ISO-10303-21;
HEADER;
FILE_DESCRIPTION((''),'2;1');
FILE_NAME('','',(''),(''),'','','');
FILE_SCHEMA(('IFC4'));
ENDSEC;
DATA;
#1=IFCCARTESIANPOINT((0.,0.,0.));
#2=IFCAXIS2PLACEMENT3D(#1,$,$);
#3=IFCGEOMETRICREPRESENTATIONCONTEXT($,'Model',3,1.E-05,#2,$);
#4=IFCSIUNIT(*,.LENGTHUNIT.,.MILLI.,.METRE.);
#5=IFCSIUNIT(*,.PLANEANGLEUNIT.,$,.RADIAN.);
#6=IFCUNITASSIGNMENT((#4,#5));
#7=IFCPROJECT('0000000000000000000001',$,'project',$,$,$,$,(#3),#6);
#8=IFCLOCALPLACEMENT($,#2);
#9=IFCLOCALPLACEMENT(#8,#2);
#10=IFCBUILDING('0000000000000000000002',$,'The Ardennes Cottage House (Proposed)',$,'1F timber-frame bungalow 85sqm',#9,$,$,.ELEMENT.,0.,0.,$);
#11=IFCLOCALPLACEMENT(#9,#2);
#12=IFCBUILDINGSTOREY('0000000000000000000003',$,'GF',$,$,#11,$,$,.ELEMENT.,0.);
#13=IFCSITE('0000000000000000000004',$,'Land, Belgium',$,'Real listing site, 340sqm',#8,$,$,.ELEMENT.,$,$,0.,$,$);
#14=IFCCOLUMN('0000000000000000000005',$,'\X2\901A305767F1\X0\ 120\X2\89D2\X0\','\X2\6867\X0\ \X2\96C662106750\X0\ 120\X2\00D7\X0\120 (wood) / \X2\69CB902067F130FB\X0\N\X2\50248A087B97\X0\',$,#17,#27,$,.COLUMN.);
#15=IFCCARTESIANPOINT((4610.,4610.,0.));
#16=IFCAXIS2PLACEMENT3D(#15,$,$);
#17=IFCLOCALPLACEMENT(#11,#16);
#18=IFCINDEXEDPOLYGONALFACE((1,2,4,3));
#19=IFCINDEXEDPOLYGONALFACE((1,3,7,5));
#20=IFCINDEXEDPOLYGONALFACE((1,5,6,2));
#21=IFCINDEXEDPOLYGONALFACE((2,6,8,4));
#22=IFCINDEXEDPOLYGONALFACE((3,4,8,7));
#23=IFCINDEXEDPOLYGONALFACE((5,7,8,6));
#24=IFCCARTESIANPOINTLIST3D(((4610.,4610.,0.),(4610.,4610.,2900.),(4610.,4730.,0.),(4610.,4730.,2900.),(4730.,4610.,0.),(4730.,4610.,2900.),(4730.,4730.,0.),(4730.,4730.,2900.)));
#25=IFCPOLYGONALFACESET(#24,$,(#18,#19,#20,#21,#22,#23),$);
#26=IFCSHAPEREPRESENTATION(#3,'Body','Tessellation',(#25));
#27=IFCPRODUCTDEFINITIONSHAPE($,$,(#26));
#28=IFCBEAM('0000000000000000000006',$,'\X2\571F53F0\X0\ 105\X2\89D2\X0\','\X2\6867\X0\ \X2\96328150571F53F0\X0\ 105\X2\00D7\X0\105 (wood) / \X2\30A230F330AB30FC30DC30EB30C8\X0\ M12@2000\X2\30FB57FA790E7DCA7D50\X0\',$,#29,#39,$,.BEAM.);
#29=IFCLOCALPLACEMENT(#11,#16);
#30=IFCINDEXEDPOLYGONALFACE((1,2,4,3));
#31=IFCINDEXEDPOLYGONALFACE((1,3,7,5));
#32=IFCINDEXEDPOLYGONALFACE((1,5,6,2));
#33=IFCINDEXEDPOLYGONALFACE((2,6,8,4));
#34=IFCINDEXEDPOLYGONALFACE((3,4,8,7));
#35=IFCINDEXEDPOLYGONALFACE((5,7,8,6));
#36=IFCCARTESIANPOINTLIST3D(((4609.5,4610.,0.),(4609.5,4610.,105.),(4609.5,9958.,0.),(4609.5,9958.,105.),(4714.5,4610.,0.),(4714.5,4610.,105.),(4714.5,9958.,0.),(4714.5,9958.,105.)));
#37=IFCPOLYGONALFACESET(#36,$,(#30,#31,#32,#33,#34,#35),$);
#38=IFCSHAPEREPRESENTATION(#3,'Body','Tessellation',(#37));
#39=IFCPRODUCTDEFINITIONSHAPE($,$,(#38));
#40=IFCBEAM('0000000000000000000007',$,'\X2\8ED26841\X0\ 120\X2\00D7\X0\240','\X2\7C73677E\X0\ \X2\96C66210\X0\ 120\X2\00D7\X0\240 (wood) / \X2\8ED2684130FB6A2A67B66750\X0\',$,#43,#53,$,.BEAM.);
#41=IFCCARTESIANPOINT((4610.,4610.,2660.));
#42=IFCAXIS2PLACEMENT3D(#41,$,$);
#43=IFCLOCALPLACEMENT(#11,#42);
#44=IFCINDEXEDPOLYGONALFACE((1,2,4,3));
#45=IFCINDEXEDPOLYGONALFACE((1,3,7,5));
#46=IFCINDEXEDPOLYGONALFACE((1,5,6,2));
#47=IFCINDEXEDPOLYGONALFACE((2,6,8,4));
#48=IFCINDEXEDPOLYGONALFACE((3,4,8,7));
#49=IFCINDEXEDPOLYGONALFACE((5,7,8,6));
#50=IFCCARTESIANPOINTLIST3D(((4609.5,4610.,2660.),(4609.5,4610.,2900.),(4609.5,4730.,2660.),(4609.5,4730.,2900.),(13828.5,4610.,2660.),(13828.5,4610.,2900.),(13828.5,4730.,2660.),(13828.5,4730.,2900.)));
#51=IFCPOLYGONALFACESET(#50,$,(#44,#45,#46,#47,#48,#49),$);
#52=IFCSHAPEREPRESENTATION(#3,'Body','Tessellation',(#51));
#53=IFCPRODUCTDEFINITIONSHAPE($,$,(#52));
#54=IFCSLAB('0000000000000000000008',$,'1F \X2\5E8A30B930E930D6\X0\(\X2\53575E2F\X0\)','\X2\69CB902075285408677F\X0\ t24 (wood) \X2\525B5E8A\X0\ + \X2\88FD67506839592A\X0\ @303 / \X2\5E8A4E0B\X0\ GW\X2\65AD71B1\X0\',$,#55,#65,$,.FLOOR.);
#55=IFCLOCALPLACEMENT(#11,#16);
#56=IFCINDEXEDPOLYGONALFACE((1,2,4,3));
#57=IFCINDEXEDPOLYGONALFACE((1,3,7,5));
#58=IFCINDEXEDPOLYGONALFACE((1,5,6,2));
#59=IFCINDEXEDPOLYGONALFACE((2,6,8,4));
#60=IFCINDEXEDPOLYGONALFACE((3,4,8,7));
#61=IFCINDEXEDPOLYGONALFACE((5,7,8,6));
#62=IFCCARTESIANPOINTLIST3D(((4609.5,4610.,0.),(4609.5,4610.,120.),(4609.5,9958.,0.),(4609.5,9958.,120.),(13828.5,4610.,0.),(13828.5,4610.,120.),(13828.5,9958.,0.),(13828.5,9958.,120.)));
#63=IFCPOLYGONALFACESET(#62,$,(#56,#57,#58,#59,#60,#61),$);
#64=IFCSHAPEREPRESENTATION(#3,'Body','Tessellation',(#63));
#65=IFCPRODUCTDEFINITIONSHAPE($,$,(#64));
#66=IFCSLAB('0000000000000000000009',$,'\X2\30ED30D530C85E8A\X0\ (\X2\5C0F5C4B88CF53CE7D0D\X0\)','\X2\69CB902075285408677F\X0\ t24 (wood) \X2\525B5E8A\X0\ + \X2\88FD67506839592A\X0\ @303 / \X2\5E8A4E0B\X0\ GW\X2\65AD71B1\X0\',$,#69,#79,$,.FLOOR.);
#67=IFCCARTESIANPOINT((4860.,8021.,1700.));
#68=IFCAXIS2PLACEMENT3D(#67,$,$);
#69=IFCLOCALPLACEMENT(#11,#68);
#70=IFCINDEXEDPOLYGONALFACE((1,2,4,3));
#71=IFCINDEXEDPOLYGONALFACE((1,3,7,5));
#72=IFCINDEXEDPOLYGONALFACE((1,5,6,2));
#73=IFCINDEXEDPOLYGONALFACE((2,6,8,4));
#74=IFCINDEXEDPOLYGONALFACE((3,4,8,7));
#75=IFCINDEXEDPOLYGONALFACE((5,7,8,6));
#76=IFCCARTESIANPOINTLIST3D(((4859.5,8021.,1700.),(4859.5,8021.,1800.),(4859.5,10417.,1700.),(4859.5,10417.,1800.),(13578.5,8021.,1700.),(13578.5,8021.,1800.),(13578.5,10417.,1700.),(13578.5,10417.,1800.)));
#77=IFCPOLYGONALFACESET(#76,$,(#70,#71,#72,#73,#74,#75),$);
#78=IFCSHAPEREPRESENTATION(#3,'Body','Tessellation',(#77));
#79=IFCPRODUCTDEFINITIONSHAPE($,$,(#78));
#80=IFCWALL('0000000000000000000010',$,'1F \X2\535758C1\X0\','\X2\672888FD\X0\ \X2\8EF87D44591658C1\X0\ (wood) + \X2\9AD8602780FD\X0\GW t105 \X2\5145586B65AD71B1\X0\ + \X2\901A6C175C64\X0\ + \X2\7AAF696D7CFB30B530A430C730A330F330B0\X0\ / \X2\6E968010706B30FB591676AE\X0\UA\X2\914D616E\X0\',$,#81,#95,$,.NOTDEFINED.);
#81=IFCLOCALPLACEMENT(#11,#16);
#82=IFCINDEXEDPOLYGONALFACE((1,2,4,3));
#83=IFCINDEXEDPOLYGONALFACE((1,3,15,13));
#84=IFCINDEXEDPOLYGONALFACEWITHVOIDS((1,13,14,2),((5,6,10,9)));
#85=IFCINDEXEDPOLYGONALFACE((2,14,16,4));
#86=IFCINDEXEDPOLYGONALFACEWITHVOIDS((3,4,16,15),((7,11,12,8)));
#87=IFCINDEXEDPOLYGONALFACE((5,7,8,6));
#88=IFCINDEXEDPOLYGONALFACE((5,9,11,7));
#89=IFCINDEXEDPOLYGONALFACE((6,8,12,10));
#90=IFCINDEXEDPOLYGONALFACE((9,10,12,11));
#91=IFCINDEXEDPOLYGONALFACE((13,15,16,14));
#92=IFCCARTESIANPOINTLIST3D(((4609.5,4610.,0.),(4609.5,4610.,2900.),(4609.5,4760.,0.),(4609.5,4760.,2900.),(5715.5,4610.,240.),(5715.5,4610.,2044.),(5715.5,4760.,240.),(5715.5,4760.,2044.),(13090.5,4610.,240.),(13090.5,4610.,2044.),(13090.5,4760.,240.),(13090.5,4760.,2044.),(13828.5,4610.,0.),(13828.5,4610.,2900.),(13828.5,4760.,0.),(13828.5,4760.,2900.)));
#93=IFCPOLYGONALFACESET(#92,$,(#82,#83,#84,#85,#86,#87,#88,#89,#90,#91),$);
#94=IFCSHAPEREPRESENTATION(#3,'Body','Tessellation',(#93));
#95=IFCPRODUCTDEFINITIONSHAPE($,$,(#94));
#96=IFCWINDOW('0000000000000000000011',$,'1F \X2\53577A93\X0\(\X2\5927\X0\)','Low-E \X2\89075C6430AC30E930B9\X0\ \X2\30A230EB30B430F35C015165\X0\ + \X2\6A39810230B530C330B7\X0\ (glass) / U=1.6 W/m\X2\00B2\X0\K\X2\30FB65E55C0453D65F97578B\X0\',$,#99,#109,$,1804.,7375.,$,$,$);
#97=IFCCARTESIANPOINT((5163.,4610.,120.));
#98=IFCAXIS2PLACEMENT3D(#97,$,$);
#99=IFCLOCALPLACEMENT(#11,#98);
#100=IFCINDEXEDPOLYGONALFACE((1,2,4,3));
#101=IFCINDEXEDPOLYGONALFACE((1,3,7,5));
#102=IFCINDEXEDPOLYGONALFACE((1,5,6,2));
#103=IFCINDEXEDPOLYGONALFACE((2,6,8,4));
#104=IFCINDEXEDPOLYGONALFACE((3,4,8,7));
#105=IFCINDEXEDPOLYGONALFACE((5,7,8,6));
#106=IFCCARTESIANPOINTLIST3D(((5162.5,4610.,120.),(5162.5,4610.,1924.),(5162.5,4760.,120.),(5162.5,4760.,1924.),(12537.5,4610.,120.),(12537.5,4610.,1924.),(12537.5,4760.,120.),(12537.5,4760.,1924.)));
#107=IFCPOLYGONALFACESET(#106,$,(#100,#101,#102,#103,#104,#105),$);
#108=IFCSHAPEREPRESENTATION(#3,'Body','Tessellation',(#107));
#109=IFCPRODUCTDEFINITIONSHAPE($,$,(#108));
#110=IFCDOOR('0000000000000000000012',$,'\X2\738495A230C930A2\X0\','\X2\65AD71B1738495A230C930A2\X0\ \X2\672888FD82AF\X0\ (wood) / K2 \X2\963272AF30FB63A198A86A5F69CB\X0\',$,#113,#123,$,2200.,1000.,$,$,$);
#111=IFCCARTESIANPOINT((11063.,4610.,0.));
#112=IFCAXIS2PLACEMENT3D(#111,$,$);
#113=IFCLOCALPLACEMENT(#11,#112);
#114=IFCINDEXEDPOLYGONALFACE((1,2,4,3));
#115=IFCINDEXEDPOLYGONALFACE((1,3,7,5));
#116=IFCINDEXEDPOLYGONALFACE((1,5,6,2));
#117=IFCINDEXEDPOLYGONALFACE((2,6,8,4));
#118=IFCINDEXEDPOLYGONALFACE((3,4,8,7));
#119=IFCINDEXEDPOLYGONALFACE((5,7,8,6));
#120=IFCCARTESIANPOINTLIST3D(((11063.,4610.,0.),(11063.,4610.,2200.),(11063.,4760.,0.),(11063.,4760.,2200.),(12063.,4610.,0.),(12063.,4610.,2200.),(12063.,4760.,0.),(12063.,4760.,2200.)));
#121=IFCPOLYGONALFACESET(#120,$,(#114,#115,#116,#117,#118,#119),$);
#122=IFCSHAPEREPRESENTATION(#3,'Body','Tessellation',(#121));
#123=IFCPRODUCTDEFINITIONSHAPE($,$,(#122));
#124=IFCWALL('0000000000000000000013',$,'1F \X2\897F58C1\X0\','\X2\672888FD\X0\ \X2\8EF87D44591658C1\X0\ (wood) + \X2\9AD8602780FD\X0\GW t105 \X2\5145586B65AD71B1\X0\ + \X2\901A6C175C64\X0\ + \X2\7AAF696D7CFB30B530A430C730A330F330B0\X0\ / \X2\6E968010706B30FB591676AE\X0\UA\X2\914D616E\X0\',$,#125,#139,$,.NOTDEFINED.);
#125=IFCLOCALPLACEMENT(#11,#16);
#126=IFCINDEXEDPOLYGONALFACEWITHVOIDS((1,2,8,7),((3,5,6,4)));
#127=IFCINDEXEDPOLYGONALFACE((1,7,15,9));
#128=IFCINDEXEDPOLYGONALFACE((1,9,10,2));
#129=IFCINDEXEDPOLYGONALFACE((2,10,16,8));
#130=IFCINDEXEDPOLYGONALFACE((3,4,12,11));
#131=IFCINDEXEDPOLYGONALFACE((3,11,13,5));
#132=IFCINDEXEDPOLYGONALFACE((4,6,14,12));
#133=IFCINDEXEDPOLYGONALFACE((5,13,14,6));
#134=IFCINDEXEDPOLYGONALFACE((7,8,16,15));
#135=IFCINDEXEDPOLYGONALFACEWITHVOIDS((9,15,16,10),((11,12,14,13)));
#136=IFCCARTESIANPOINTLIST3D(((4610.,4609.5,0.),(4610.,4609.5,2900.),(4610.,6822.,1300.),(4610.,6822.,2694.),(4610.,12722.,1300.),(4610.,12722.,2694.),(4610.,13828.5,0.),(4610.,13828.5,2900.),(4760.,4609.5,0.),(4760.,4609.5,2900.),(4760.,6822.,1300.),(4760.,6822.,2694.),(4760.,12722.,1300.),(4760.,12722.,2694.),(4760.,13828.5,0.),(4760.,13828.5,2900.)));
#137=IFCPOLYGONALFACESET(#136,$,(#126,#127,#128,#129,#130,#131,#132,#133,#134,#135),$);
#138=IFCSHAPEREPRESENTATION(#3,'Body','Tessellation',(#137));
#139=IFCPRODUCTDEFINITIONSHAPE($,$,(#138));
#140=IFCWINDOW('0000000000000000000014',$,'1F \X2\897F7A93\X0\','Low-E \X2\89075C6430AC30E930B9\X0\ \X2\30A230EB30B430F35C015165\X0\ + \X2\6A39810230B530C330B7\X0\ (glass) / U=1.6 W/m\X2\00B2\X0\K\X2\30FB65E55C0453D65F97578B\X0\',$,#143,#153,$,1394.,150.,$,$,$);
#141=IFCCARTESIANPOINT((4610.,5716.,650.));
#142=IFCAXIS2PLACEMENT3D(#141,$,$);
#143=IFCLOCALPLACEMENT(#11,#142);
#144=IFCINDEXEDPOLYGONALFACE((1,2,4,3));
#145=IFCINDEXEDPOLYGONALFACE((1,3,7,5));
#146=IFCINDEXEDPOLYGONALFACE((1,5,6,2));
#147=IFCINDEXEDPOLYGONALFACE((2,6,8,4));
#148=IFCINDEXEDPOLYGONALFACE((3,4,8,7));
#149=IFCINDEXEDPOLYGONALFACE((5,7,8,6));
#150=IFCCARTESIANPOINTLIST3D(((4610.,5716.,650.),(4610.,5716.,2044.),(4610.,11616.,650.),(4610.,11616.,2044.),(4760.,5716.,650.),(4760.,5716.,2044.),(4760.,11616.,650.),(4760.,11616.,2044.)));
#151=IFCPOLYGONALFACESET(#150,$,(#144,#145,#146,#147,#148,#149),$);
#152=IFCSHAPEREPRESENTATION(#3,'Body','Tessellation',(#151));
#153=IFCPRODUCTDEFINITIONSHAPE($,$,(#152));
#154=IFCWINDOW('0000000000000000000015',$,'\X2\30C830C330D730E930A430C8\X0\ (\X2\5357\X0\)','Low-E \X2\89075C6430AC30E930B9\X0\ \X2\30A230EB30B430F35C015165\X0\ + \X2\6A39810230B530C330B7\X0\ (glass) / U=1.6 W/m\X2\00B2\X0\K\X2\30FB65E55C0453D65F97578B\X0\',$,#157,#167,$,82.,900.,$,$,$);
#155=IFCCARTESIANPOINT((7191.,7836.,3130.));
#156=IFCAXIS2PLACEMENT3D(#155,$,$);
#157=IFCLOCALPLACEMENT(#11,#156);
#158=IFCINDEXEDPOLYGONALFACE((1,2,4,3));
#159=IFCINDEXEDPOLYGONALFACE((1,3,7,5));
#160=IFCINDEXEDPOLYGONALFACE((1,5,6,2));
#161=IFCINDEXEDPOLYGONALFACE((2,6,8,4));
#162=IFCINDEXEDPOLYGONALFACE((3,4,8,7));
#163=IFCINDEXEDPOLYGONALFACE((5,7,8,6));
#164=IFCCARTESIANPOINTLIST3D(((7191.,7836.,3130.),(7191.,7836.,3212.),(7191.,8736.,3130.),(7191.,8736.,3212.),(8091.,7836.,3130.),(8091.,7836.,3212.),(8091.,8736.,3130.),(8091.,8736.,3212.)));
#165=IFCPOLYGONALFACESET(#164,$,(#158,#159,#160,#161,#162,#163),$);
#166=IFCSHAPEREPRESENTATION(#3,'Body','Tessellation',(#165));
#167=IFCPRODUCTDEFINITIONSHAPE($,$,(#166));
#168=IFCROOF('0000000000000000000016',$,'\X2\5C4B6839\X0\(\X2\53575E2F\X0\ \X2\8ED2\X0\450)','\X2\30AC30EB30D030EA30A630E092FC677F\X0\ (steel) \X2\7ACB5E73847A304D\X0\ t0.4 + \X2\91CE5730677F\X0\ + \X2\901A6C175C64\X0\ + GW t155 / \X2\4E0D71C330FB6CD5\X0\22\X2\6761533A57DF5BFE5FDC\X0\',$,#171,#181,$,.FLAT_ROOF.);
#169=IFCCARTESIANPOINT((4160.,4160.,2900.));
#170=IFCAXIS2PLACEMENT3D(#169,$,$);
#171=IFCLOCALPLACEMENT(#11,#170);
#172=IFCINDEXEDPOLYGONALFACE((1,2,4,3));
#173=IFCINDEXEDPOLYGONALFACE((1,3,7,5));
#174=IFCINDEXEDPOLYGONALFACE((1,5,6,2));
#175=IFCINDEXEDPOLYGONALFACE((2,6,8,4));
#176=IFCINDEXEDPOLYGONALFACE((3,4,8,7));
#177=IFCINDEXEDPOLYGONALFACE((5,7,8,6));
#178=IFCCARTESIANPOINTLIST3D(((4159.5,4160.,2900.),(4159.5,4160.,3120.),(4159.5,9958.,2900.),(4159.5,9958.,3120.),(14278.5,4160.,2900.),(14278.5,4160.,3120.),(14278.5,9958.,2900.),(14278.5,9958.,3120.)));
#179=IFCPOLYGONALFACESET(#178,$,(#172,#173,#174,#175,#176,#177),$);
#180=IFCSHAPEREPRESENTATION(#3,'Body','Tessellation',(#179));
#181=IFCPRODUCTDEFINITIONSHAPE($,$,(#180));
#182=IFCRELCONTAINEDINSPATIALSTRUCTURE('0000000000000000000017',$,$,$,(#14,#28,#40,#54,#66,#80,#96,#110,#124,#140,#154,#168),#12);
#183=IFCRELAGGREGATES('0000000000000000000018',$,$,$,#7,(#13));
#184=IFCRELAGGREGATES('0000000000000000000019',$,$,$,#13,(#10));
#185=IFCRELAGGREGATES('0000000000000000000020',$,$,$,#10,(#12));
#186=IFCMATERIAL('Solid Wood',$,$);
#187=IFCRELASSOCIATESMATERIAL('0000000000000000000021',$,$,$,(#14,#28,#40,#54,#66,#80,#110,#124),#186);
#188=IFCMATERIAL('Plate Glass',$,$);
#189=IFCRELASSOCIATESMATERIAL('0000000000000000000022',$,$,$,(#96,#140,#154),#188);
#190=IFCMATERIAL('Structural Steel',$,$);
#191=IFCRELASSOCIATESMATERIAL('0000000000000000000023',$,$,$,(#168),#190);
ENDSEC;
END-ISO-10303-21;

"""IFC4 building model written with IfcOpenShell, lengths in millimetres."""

from ifc_helpers import new_model, si_unit, frame, frame_2d, origin, place, context, project, spatial, rectangle, extrude, material, element, fill, save


model = new_model("IFC4")

# Units and contexts
model_context = context("Model", 3, precision=1e-05, world=origin())
ifc_project = project(units=[si_unit("LENGTHUNIT", "METRE", prefix="MILLI"), si_unit("PLANEANGLEUNIT", "RADIAN")], contexts=[model_context])

# Site, building, storey
site_placement = place(None, origin())
site = spatial("IfcSite", under=ifc_project, at=site_placement, Name="Land, Belgium", ObjectType="Real listing site, 340sqm", CompositionType="ELEMENT", RefElevation=0.0)
building_placement = place(site_placement, origin())
building = spatial("IfcBuilding", under=site, at=building_placement, Name="The Ardennes Cottage House (Proposed)", ObjectType="1F timber-frame bungalow 85sqm", CompositionType="ELEMENT", ElevationOfRefHeight=0.0, ElevationOfTerrain=0.0)
storey_placement = place(building_placement, origin())
storey = spatial("IfcBuildingStorey", under=building, at=storey_placement, Name="GF", CompositionType="ELEMENT", Elevation=0.0)

# Column
ifc_material_1 = material(Name="Solid Wood")
column_1_placement = place(storey_placement, frame((4610.0, 4610.0, 0.0)))
element("IfcColumn", 1, at=column_1_placement, inside=storey, material=ifc_material_1, Name="通し柱 120角", Description="桧 集成材 120×120 (wood) / 構造柱・N値計算", PredefinedType="COLUMN", context=model_context, shape_type="SweptSolid", body=[
    extrude(rectangle(XDim=120.0, YDim=120.0, at=frame_2d((60.0, 60.0))), frame((4610.0, 4610.0, 0.0)), (0.0, 0.0, 1.0), 2900.0),
])

# Beams
beam_1_placement = place(storey_placement, frame((4610.0, 4610.0, 0.0)))
element("IfcBeam", 2, at=beam_1_placement, inside=storey, material=ifc_material_1, Name="土台 105角", Description="桧 防腐土台 105×105 (wood) / アンカーボルト M12@2000・基礎緊結", PredefinedType="BEAM", context=model_context, shape_type="SweptSolid", body=[
    extrude(rectangle(XDim=105.0, YDim=5348.0, at=frame_2d((52.0, 2674.0))), frame((4610.0, 4610.0, 0.0)), (0.0, 0.0, 1.0), 105.0),
])
beam_2_placement = place(storey_placement, frame((4610.0, 4610.0, 2660.0)))
element("IfcBeam", 3, at=beam_2_placement, inside=storey, material=ifc_material_1, Name="軒桁 120×240", Description="米松 集成 120×240 (wood) / 軒桁・横架材", PredefinedType="BEAM", context=model_context, shape_type="SweptSolid", body=[
    extrude(rectangle(XDim=9219.0, YDim=120.0, at=frame_2d((4609.0, 60.0))), frame((4610.0, 4610.0, 2660.0)), (0.0, 0.0, 1.0), 240.0),
])

# Slabs
slab_1_placement = place(storey_placement, frame((4610.0, 4610.0, 0.0)))
element("IfcSlab", 4, at=slab_1_placement, inside=storey, material=ifc_material_1, Name="1F 床スラブ(南帯)", Description="構造用合板 t24 (wood) 剛床 + 製材根太 @303 / 床下 GW断熱", PredefinedType="FLOOR", context=model_context, shape_type="SweptSolid", body=[
    extrude(rectangle(XDim=9219.0, YDim=5348.0, at=frame_2d((4609.0, 2674.0))), frame((4610.0, 4610.0, 0.0)), (0.0, 0.0, 1.0), 120.0),
])
slab_2_placement = place(storey_placement, frame((4860.0, 8021.0, 1700.0)))
element("IfcSlab", 5, at=slab_2_placement, inside=storey, material=ifc_material_1, Name="ロフト床 (小屋裏収納)", Description="構造用合板 t24 (wood) 剛床 + 製材根太 @303 / 床下 GW断熱", PredefinedType="FLOOR", context=model_context, shape_type="SweptSolid", body=[
    extrude(rectangle(XDim=8719.0, YDim=2396.0, at=frame_2d((4359.0, 1198.0))), frame((4860.0, 8021.0, 1700.0)), (0.0, 0.0, 1.0), 100.0),
])

# Wall, openings, window, door
wall_1_placement = place(storey_placement, frame((4610.0, 4610.0, 0.0)))
wall_1 = element("IfcWall", 6, at=wall_1_placement, inside=storey, material=ifc_material_1, Name="1F 南壁", Description="木製 軸組外壁 (wood) + 高性能GW t105 充填断熱 + 通気層 + 窯業系サイディング / 準耐火・外皮UA配慮", PredefinedType="NOTDEFINED", context=model_context, shape_type="SweptSolid", body=[
    extrude(rectangle(XDim=9219.0, YDim=150.0, at=frame_2d((4609.0, 75.0))), frame((4610.0, 4610.0, 0.0)), (0.0, 0.0, 1.0), 2900.0),
])
opening_1_placement = place(storey_placement, frame((5163.0, 4610.0, 120.0)))
opening_1 = element("IfcOpeningElement", 7, at=opening_1_placement, cuts=wall_1, PredefinedType="NOTDEFINED", context=model_context, shape_type="SweptSolid", body=[
    extrude(rectangle(XDim=7375.0, YDim=150.0, at=frame_2d((3687.0, 75.0))), frame((5163.0, 4610.0, 120.0)), (0.0, 0.0, 1.0), 1804.0),
])
opening_2_placement = place(storey_placement, frame((11063.0, 4610.0, 0.0)))
opening_2 = element("IfcOpeningElement", 8, at=opening_2_placement, cuts=wall_1, PredefinedType="NOTDEFINED", context=model_context, shape_type="SweptSolid", body=[
    extrude(rectangle(XDim=1000.0, YDim=150.0, at=frame_2d((500.0, 75.0))), frame((11063.0, 4610.0, 0.0)), (0.0, 0.0, 1.0), 2200.0),
])
ifc_material_2 = material(Name="Plate Glass")
window_1_placement = place(storey_placement, frame((5163.0, 4610.0, 120.0)))
window_1 = element("IfcWindow", 9, at=window_1_placement, inside=storey, material=ifc_material_2, Name="1F 南窓(大)", Description="Low-E 複層ガラス アルゴン封入 + 樹脂サッシ (glass) / U=1.6 W/m²K・日射取得型", OverallHeight=1804.0, OverallWidth=7375.0, context=model_context, shape_type="SweptSolid", body=[
    extrude(rectangle(XDim=7375.0, YDim=150.0, at=frame_2d((3687.0, 75.0))), frame((5163.0, 4610.0, 120.0)), (0.0, 0.0, 1.0), 1804.0),
])
fill(opening_1, window_1)
door_1_placement = place(storey_placement, frame((11063.0, 4610.0, 0.0)))
door_1 = element("IfcDoor", 10, at=door_1_placement, inside=storey, material=ifc_material_1, Name="玄関ドア", Description="断熱玄関ドア 木製芯 (wood) / K2 防犯・採風機構", OverallHeight=2200.0, OverallWidth=1000.0, context=model_context, shape_type="SweptSolid", body=[
    extrude(rectangle(XDim=1000.0, YDim=150.0, at=frame_2d((500.0, 75.0))), frame((11063.0, 4610.0, 0.0)), (0.0, 0.0, 1.0), 2200.0),
])
fill(opening_2, door_1)

# Wall, opening, window
wall_2_placement = place(storey_placement, frame((4610.0, 4610.0, 0.0)))
wall_2 = element("IfcWall", 11, at=wall_2_placement, inside=storey, material=ifc_material_1, Name="1F 西壁", Description="木製 軸組外壁 (wood) + 高性能GW t105 充填断熱 + 通気層 + 窯業系サイディング / 準耐火・外皮UA配慮", PredefinedType="NOTDEFINED", context=model_context, shape_type="SweptSolid", body=[
    extrude(rectangle(XDim=150.0, YDim=9219.0, at=frame_2d((75.0, 4609.0))), frame((4610.0, 4610.0, 0.0)), (0.0, 0.0, 1.0), 2900.0),
])
opening_3_placement = place(storey_placement, frame((4610.0, 5716.0, 650.0)))
opening_3 = element("IfcOpeningElement", 12, at=opening_3_placement, cuts=wall_2, PredefinedType="NOTDEFINED", context=model_context, shape_type="SweptSolid", body=[
    extrude(rectangle(XDim=150.0, YDim=5900.0, at=frame_2d((75.0, 2950.0))), frame((4610.0, 5716.0, 650.0)), (0.0, 0.0, 1.0), 1394.0),
])
window_2_placement = place(storey_placement, frame((4610.0, 5716.0, 650.0)))
window_2 = element("IfcWindow", 13, at=window_2_placement, inside=storey, material=ifc_material_2, Name="1F 西窓", Description="Low-E 複層ガラス アルゴン封入 + 樹脂サッシ (glass) / U=1.6 W/m²K・日射取得型", OverallHeight=1394.0, OverallWidth=150.0, context=model_context, shape_type="SweptSolid", body=[
    extrude(rectangle(XDim=150.0, YDim=5900.0, at=frame_2d((75.0, 2950.0))), frame((4610.0, 5716.0, 650.0)), (0.0, 0.0, 1.0), 1394.0),
])
fill(opening_3, window_2)

# Window
window_3_placement = place(storey_placement, frame((7191.0, 7836.0, 3130.0)))
element("IfcWindow", 14, at=window_3_placement, inside=storey, material=ifc_material_2, Name="トップライト (南)", Description="Low-E 複層ガラス アルゴン封入 + 樹脂サッシ (glass) / U=1.6 W/m²K・日射取得型", OverallHeight=82.0, OverallWidth=900.0, context=model_context, shape_type="SweptSolid", body=[
    extrude(rectangle(XDim=900.0, YDim=900.0, at=frame_2d((450.0, 450.0))), frame((7191.0, 7836.0, 3130.0)), (0.0, 0.0, 1.0), 82.0),
])

# Roof
ifc_material_3 = material(Name="Structural Steel")
roof_placement = place(storey_placement, frame((4160.0, 4160.0, 2900.0)))
element("IfcRoof", 15, at=roof_placement, inside=storey, material=ifc_material_3, Name="屋根(南帯 軒450)", Description="ガルバリウム鋼板 (steel) 立平葺き t0.4 + 野地板 + 通気層 + GW t155 / 不燃・法22条区域対応", PredefinedType="FLAT_ROOF", context=model_context, shape_type="SweptSolid", body=[
    extrude(rectangle(XDim=10119.0, YDim=5798.0, at=frame_2d((5059.0, 2899.0))), frame((4160.0, 4160.0, 2900.0)), (0.0, 0.0, 1.0), 220.0),
])

save(model, "model.ifc")
